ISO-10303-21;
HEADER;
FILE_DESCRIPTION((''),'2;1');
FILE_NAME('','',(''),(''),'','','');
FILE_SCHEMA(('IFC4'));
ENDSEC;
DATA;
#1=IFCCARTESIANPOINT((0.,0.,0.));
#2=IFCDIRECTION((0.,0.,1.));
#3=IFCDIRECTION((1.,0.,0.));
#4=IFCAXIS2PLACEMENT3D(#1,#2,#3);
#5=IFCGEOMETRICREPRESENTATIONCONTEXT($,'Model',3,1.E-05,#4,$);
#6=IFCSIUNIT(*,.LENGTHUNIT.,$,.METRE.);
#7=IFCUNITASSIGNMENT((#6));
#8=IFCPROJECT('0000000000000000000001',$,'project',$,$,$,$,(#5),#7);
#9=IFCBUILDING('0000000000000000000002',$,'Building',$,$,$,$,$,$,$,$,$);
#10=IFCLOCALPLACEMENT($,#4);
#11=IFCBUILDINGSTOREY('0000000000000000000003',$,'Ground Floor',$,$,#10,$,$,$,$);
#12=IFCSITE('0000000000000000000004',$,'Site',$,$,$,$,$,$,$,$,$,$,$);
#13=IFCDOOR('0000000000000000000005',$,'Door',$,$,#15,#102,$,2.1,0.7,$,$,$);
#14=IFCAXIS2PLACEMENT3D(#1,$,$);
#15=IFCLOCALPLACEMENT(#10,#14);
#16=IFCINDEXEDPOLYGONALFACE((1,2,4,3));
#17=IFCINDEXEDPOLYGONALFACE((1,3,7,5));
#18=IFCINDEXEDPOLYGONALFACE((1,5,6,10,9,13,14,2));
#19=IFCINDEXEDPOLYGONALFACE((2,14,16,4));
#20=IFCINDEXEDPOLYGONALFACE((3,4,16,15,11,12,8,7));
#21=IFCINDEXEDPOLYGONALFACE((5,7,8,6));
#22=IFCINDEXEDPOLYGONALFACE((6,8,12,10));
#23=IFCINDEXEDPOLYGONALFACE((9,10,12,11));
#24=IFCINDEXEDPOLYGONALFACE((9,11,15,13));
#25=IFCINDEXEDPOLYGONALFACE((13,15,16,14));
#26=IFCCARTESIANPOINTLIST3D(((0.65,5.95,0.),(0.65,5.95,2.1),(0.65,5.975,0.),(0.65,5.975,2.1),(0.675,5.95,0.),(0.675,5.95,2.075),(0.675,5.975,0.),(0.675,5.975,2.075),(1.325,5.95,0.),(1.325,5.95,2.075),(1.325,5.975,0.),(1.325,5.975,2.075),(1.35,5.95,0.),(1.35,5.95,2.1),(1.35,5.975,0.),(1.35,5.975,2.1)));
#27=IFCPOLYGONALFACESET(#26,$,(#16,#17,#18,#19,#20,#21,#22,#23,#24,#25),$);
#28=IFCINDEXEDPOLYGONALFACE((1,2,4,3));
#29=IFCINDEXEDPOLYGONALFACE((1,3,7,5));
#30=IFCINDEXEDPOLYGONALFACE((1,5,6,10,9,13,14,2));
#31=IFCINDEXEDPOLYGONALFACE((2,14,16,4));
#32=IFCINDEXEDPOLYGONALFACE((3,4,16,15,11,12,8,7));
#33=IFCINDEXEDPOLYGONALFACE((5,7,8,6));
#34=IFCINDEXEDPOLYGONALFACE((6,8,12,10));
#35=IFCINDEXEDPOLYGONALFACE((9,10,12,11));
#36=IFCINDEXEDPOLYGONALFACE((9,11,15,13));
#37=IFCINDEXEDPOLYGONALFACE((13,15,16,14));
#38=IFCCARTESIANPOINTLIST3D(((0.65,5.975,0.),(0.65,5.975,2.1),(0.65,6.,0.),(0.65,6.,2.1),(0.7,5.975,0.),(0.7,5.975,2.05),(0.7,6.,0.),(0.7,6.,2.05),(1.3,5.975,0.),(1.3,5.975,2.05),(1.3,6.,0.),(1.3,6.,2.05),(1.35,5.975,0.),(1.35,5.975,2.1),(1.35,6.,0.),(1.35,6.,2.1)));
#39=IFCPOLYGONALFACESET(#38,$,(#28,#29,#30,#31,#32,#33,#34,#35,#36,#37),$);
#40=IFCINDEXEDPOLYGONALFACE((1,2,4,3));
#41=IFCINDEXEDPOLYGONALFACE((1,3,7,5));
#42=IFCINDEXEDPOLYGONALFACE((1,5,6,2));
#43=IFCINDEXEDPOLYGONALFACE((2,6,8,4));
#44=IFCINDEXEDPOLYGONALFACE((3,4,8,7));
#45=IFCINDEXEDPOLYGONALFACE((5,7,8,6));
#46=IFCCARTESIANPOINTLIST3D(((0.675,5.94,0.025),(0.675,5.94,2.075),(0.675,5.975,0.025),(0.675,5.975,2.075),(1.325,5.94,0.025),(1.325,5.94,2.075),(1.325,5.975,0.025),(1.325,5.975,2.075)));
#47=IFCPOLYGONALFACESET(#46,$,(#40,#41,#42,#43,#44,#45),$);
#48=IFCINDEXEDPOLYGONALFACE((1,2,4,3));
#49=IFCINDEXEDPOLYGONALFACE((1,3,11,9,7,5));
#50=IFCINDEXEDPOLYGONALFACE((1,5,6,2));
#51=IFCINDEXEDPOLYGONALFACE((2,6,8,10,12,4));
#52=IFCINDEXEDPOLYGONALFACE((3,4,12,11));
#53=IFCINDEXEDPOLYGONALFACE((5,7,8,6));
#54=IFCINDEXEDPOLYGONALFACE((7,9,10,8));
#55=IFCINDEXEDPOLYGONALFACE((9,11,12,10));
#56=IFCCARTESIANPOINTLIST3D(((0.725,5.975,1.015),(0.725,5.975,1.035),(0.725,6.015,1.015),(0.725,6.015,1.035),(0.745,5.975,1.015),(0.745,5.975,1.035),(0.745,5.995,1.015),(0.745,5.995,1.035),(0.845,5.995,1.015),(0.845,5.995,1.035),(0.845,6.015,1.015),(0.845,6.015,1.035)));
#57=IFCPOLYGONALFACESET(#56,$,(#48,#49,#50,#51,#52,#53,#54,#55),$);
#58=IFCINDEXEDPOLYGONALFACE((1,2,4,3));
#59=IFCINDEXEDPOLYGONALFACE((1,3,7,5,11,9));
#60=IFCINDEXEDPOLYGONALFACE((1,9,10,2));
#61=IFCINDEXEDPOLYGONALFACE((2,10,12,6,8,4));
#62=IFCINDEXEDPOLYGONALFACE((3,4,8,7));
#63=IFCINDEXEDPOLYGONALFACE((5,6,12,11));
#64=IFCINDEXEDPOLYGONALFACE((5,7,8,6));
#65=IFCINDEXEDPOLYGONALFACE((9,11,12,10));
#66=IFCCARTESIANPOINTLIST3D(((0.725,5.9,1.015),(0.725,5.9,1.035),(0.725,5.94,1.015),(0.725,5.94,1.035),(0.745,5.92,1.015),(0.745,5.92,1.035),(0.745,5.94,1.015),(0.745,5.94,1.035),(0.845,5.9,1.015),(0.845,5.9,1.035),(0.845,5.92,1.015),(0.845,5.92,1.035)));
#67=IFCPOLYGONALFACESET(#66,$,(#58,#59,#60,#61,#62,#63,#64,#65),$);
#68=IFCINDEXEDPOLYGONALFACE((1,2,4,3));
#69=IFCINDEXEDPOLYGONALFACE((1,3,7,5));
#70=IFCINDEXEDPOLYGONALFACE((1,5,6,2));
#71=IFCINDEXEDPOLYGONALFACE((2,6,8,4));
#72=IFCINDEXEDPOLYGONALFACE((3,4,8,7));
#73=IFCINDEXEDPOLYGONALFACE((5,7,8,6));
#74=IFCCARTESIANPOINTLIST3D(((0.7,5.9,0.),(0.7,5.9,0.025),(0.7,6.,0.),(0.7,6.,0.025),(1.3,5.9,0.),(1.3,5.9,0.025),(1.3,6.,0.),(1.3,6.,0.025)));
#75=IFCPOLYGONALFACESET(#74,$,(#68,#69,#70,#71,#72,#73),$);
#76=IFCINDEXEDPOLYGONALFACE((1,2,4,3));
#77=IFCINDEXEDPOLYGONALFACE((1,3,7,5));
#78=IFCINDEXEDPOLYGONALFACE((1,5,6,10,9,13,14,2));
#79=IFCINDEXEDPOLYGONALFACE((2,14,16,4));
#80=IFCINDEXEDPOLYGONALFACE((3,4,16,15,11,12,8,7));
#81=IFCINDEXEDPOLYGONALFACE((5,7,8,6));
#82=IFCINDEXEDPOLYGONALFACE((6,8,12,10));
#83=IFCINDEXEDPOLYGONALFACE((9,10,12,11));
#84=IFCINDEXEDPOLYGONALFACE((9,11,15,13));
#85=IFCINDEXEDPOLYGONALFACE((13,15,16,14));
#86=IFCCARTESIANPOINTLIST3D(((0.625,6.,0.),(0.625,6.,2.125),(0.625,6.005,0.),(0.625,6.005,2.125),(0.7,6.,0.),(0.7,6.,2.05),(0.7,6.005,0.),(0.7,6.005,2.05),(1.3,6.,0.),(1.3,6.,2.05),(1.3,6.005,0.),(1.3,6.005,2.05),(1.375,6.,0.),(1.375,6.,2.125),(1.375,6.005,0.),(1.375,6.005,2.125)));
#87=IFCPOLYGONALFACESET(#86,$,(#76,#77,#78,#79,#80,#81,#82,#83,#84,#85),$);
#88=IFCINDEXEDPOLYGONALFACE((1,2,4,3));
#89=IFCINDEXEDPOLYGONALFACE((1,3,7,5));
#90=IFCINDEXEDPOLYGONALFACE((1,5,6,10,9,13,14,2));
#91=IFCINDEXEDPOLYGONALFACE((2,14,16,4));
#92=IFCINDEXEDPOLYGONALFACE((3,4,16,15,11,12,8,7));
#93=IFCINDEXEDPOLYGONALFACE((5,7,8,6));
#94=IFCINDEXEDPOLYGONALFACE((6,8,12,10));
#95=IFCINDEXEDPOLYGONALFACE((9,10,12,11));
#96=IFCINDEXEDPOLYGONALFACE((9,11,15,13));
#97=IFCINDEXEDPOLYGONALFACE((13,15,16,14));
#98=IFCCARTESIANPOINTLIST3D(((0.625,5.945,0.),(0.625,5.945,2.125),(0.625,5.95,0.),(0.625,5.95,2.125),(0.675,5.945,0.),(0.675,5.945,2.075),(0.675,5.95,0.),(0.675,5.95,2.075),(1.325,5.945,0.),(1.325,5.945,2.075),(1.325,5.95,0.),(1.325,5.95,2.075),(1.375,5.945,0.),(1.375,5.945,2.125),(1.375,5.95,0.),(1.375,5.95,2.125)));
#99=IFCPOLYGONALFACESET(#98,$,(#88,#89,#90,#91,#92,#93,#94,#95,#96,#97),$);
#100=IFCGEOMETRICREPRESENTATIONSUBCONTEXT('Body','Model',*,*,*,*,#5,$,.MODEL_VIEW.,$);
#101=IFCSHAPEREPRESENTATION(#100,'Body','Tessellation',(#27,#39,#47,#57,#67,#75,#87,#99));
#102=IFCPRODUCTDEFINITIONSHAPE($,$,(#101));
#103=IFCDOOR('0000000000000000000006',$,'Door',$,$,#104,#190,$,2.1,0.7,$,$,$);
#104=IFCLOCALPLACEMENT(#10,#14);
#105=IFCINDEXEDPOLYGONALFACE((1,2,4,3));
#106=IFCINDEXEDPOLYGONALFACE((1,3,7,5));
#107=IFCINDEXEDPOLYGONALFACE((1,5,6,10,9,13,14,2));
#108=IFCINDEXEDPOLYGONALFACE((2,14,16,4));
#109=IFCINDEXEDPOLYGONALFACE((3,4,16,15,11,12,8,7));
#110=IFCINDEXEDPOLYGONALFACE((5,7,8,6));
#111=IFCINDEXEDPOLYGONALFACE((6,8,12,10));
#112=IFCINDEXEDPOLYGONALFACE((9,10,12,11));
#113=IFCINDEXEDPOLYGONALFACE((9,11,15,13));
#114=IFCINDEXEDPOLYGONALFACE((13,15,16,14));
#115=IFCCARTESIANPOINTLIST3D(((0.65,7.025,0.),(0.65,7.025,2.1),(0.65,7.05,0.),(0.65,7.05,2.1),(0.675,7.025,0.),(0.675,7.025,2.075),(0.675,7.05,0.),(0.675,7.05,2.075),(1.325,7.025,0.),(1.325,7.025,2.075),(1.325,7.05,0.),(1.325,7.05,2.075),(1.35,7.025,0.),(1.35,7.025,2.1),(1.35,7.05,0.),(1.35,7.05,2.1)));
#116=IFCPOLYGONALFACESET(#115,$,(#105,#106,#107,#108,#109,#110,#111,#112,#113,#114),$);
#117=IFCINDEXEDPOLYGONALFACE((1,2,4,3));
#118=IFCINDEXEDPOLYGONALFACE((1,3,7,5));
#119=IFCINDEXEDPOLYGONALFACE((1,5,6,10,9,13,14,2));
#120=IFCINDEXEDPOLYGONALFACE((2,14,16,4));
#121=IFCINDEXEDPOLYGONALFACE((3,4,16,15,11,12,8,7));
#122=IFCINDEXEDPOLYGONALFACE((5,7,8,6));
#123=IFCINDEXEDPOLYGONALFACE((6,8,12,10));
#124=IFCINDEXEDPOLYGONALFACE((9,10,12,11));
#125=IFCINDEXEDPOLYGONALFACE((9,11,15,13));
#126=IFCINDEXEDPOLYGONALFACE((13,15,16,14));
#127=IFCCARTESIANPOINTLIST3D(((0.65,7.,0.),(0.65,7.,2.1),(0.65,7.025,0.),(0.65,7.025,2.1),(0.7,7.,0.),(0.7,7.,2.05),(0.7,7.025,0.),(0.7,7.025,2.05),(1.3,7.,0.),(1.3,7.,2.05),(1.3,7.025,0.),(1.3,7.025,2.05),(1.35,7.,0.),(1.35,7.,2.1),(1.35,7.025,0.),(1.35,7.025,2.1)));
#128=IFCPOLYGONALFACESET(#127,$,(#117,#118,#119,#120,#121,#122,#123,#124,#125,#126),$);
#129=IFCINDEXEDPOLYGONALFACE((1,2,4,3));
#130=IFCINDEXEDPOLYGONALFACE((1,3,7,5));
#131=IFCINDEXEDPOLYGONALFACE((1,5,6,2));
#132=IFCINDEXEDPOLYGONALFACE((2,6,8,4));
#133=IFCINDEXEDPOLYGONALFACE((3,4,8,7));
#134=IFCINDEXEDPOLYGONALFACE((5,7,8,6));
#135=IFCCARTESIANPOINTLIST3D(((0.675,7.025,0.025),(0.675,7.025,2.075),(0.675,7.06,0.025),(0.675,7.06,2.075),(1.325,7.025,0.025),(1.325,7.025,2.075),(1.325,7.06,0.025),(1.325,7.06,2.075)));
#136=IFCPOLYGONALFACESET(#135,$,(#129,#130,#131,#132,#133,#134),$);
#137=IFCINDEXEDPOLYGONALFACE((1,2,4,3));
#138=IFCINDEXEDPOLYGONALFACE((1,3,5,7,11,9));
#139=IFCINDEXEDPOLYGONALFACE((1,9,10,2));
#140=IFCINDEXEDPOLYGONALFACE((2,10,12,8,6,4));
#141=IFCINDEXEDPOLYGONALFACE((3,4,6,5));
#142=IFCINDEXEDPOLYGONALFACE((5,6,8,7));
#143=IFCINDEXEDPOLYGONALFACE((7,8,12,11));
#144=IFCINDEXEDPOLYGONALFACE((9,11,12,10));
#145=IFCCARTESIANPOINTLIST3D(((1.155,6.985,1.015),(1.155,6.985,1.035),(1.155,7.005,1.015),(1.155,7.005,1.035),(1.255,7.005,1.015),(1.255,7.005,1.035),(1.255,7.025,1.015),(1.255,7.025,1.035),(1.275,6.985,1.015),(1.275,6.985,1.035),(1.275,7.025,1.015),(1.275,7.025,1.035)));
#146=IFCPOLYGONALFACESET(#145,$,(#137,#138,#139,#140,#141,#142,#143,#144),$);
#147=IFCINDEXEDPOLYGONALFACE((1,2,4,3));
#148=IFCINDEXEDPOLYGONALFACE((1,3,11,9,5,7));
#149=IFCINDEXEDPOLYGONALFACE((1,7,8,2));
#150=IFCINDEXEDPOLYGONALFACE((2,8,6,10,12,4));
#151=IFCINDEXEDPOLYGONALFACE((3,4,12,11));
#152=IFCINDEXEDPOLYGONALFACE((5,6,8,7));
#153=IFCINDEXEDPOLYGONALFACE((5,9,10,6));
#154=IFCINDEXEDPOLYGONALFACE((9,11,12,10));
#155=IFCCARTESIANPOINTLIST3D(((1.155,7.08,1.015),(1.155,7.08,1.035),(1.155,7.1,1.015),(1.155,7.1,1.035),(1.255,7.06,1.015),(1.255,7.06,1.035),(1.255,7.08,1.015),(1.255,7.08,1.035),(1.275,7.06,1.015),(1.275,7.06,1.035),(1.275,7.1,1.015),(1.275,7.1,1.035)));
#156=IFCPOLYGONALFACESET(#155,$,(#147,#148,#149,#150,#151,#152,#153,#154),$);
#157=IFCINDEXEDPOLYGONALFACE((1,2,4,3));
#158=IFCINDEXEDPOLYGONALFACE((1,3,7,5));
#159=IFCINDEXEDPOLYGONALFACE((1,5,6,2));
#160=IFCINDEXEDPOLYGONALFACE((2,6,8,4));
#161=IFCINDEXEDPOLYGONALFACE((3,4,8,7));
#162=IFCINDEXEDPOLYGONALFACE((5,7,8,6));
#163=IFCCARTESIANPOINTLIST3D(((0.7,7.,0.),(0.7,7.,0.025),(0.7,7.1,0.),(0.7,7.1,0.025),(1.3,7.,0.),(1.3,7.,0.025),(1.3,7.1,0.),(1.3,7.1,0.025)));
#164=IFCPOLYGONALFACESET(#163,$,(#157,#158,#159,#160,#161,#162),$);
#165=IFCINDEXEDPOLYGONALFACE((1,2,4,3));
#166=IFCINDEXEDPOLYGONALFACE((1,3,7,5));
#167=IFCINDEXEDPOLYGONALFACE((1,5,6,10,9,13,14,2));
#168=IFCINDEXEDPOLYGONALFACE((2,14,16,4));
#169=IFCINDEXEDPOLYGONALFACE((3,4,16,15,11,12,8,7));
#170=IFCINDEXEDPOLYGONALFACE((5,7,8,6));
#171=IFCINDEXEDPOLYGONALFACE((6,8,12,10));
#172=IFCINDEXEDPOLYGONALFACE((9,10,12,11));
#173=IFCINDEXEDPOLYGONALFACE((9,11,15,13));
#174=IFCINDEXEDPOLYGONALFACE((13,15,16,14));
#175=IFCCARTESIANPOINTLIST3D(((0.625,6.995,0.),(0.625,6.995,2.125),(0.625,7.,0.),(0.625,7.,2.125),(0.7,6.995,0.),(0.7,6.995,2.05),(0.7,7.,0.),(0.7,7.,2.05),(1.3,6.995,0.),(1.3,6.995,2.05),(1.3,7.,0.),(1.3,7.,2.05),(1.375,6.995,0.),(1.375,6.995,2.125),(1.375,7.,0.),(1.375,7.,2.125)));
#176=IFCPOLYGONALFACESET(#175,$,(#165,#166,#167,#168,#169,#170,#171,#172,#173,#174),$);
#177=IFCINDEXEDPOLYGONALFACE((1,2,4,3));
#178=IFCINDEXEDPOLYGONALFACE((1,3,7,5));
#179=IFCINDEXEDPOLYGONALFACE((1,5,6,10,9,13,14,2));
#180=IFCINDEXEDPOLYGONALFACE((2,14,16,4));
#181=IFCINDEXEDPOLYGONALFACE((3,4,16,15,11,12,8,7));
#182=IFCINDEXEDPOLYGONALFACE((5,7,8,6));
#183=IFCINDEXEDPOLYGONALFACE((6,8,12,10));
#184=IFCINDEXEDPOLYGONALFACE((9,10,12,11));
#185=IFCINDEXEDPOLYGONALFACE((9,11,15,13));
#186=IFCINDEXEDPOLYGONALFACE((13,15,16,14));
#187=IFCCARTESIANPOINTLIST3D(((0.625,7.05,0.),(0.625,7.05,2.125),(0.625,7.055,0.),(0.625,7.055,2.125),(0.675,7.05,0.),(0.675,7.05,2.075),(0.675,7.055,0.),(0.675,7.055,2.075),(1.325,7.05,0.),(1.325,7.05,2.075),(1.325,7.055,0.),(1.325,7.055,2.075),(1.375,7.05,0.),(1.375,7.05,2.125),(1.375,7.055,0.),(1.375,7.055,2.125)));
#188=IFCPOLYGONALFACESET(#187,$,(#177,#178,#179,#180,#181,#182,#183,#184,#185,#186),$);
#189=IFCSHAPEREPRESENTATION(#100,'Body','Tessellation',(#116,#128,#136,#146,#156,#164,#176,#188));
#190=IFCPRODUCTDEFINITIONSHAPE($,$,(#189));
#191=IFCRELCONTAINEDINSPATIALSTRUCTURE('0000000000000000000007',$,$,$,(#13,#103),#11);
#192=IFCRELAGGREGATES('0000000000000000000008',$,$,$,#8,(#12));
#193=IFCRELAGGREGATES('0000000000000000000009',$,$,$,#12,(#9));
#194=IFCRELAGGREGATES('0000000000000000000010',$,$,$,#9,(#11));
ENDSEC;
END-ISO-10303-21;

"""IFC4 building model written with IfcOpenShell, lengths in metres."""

from ifc_helpers import new_model, si_unit, frame, origin_with_axes, place, context, subcontext, project, spatial, line, indexed_curve, outline, extrude, element, save


model = new_model("IFC4")

# Units and contexts
model_context = context("Model", 3, precision=1e-05, world=origin_with_axes())
body_context = subcontext(model_context, "Body", "Model", "MODEL_VIEW")
ifc_project = project(units=[si_unit("LENGTHUNIT", "METRE")], contexts=[model_context])

# Site, building, storey
site = spatial("IfcSite", under=ifc_project, Name="Site")
building = spatial("IfcBuilding", under=site, Name="Building")
storey_placement = place(None, origin_with_axes())
storey = spatial("IfcBuildingStorey", under=building, at=storey_placement, Name="Ground Floor")

# Doors
door_1_placement = place(storey_placement, frame((1.35, 6.0, 0.0), z_axis=(0.0, 0.0, 1.0), x_axis=(-1.0, 0.0, 0.0)))
element("IfcDoor", 1, at=door_1_placement, inside=storey, Name="Door", OverallHeight=2.1, OverallWidth=0.7, context=body_context, shape_type="SweptSolid", body=[
    extrude(outline(indexed_curve([(0.0, 0.0), (0.0, 2.1), (0.7, 2.1), (0.7, 0.0), (0.675, 0.0), (0.675, 2.075), (0.025, 2.075), (0.025, 0.0)], segments=[line(1, 2, 3, 4, 5, 6, 7, 8, 1)])), frame((0.0, 0.025, 0.0), z_axis=(0.0, -1.0, 0.0), x_axis=(1.0, 0.0, 0.0)), (0.0, 0.0, -1.0), 0.025),
    extrude(outline(indexed_curve([(0.0, 0.0), (0.0, 2.1), (0.7, 2.1), (0.7, 0.0), (0.65, 0.0), (0.65, 2.05), (0.05, 2.05), (0.05, 0.0)], segments=[line(1, 2, 3, 4, 5, 6, 7, 8, 1)])), frame((0.0, 0.0, 0.0), z_axis=(0.0, -1.0, 0.0), x_axis=(1.0, 0.0, 0.0)), (0.0, 0.0, -1.0), 0.025),
    extrude(outline(indexed_curve([(0.0, 0.0), (0.65, 0.0), (0.65, 0.035), (0.0, 0.035)], segments=[line(1, 2, 3, 4, 1)])), frame((0.025, 0.025, 0.025), z_axis=(0.0, 0.0, 1.0), x_axis=(1.0, 0.0, 0.0)), (0.0, 0.0, 1.0), 2.05),
    extrude(outline(indexed_curve([(0.0, 0.0), (0.0, -0.04), (-0.12, -0.04), (-0.12, -0.02), (-0.02, -0.02), (-0.02, 0.0)], segments=[line(1, 2, 3, 4, 5, 6, 1)])), frame((0.625, 0.025, 1.015), z_axis=(0.0, 0.0, 1.0), x_axis=(1.0, 0.0, 0.0)), (0.0, 0.0, 1.0), 0.02),
    extrude(outline(indexed_curve([(0.0, 0.0), (0.0, 0.04), (-0.12, 0.04), (-0.12, 0.02), (-0.02, 0.02), (-0.02, 0.0)], segments=[line(1, 2, 3, 4, 5, 6, 1)])), frame((0.625, 0.06, 1.015), z_axis=(0.0, 0.0, 1.0), x_axis=(1.0, 0.0, 0.0)), (0.0, 0.0, 1.0), 0.02),
    extrude(outline(indexed_curve([(0.0, 0.0), (0.6, 0.0), (0.6, 0.1), (0.0, 0.1)], segments=[line(1, 2, 3, 4, 1)])), frame((0.05, 0.0, 0.0), z_axis=(0.0, 0.0, 1.0), x_axis=(1.0, 0.0, 0.0)), (0.0, 0.0, 1.0), 0.025),
    extrude(outline(indexed_curve([(0.0, 0.0), (0.0, 2.125), (0.75, 2.125), (0.75, 0.0), (0.675, 0.0), (0.675, 2.05), (0.075, 2.05), (0.075, 0.0)], segments=[line(1, 2, 3, 4, 5, 6, 7, 8, 1)])), frame((-0.025, -0.005, 0.0), z_axis=(0.0, -1.0, 0.0), x_axis=(1.0, 0.0, 0.0)), (0.0, 0.0, -1.0), 0.005),
    extrude(outline(indexed_curve([(0.0, 0.0), (0.0, 2.125), (0.75, 2.125), (0.75, 0.0), (0.7, 0.0), (0.7, 2.075), (0.05, 2.075), (0.05, 0.0)], segments=[line(1, 2, 3, 4, 5, 6, 7, 8, 1)])), frame((-0.025, 0.05, 0.0), z_axis=(0.0, -1.0, 0.0), x_axis=(1.0, 0.0, 0.0)), (0.0, 0.0, -1.0), 0.005),
])
door_2_placement = place(storey_placement, frame((0.65, 7.0, 0.0), z_axis=(0.0, 0.0, 1.0), x_axis=(1.0, 0.0, 0.0)))
element("IfcDoor", 2, at=door_2_placement, inside=storey, Name="Door", OverallHeight=2.1, OverallWidth=0.7, context=body_context, shape_type="SweptSolid", body=[
    extrude(outline(indexed_curve([(0.0, 0.0), (0.0, 2.1), (0.7, 2.1), (0.7, 0.0), (0.675, 0.0), (0.675, 2.075), (0.025, 2.075), (0.025, 0.0)], segments=[line(1, 2, 3, 4, 5, 6, 7, 8, 1)])), frame((0.0, 0.025, 0.0), z_axis=(0.0, -1.0, 0.0), x_axis=(1.0, 0.0, 0.0)), (0.0, 0.0, -1.0), 0.025),
    extrude(outline(indexed_curve([(0.0, 0.0), (0.0, 2.1), (0.7, 2.1), (0.7, 0.0), (0.65, 0.0), (0.65, 2.05), (0.05, 2.05), (0.05, 0.0)], segments=[line(1, 2, 3, 4, 5, 6, 7, 8, 1)])), frame((0.0, 0.0, 0.0), z_axis=(0.0, -1.0, 0.0), x_axis=(1.0, 0.0, 0.0)), (0.0, 0.0, -1.0), 0.025),
    extrude(outline(indexed_curve([(0.0, 0.0), (0.65, 0.0), (0.65, 0.035), (0.0, 0.035)], segments=[line(1, 2, 3, 4, 1)])), frame((0.025, 0.025, 0.025), z_axis=(0.0, 0.0, 1.0), x_axis=(1.0, 0.0, 0.0)), (0.0, 0.0, 1.0), 2.05),
    extrude(outline(indexed_curve([(0.0, 0.0), (0.0, -0.04), (-0.12, -0.04), (-0.12, -0.02), (-0.02, -0.02), (-0.02, 0.0)], segments=[line(1, 2, 3, 4, 5, 6, 1)])), frame((0.625, 0.025, 1.015), z_axis=(0.0, 0.0, 1.0), x_axis=(1.0, 0.0, 0.0)), (0.0, 0.0, 1.0), 0.02),
    extrude(outline(indexed_curve([(0.0, 0.0), (0.0, 0.04), (-0.12, 0.04), (-0.12, 0.02), (-0.02, 0.02), (-0.02, 0.0)], segments=[line(1, 2, 3, 4, 5, 6, 1)])), frame((0.625, 0.06, 1.015), z_axis=(0.0, 0.0, 1.0), x_axis=(1.0, 0.0, 0.0)), (0.0, 0.0, 1.0), 0.02),
    extrude(outline(indexed_curve([(0.0, 0.0), (0.6, 0.0), (0.6, 0.1), (0.0, 0.1)], segments=[line(1, 2, 3, 4, 1)])), frame((0.05, 0.0, 0.0), z_axis=(0.0, 0.0, 1.0), x_axis=(1.0, 0.0, 0.0)), (0.0, 0.0, 1.0), 0.025),
    extrude(outline(indexed_curve([(0.0, 0.0), (0.0, 2.125), (0.75, 2.125), (0.75, 0.0), (0.675, 0.0), (0.675, 2.05), (0.075, 2.05), (0.075, 0.0)], segments=[line(1, 2, 3, 4, 5, 6, 7, 8, 1)])), frame((-0.025, -0.005, 0.0), z_axis=(0.0, -1.0, 0.0), x_axis=(1.0, 0.0, 0.0)), (0.0, 0.0, -1.0), 0.005),
    extrude(outline(indexed_curve([(0.0, 0.0), (0.0, 2.125), (0.75, 2.125), (0.75, 0.0), (0.7, 0.0), (0.7, 2.075), (0.05, 2.075), (0.05, 0.0)], segments=[line(1, 2, 3, 4, 5, 6, 7, 8, 1)])), frame((-0.025, 0.05, 0.0), z_axis=(0.0, -1.0, 0.0), x_axis=(1.0, 0.0, 0.0)), (0.0, 0.0, -1.0), 0.005),
])

save(model, "model.ifc")
